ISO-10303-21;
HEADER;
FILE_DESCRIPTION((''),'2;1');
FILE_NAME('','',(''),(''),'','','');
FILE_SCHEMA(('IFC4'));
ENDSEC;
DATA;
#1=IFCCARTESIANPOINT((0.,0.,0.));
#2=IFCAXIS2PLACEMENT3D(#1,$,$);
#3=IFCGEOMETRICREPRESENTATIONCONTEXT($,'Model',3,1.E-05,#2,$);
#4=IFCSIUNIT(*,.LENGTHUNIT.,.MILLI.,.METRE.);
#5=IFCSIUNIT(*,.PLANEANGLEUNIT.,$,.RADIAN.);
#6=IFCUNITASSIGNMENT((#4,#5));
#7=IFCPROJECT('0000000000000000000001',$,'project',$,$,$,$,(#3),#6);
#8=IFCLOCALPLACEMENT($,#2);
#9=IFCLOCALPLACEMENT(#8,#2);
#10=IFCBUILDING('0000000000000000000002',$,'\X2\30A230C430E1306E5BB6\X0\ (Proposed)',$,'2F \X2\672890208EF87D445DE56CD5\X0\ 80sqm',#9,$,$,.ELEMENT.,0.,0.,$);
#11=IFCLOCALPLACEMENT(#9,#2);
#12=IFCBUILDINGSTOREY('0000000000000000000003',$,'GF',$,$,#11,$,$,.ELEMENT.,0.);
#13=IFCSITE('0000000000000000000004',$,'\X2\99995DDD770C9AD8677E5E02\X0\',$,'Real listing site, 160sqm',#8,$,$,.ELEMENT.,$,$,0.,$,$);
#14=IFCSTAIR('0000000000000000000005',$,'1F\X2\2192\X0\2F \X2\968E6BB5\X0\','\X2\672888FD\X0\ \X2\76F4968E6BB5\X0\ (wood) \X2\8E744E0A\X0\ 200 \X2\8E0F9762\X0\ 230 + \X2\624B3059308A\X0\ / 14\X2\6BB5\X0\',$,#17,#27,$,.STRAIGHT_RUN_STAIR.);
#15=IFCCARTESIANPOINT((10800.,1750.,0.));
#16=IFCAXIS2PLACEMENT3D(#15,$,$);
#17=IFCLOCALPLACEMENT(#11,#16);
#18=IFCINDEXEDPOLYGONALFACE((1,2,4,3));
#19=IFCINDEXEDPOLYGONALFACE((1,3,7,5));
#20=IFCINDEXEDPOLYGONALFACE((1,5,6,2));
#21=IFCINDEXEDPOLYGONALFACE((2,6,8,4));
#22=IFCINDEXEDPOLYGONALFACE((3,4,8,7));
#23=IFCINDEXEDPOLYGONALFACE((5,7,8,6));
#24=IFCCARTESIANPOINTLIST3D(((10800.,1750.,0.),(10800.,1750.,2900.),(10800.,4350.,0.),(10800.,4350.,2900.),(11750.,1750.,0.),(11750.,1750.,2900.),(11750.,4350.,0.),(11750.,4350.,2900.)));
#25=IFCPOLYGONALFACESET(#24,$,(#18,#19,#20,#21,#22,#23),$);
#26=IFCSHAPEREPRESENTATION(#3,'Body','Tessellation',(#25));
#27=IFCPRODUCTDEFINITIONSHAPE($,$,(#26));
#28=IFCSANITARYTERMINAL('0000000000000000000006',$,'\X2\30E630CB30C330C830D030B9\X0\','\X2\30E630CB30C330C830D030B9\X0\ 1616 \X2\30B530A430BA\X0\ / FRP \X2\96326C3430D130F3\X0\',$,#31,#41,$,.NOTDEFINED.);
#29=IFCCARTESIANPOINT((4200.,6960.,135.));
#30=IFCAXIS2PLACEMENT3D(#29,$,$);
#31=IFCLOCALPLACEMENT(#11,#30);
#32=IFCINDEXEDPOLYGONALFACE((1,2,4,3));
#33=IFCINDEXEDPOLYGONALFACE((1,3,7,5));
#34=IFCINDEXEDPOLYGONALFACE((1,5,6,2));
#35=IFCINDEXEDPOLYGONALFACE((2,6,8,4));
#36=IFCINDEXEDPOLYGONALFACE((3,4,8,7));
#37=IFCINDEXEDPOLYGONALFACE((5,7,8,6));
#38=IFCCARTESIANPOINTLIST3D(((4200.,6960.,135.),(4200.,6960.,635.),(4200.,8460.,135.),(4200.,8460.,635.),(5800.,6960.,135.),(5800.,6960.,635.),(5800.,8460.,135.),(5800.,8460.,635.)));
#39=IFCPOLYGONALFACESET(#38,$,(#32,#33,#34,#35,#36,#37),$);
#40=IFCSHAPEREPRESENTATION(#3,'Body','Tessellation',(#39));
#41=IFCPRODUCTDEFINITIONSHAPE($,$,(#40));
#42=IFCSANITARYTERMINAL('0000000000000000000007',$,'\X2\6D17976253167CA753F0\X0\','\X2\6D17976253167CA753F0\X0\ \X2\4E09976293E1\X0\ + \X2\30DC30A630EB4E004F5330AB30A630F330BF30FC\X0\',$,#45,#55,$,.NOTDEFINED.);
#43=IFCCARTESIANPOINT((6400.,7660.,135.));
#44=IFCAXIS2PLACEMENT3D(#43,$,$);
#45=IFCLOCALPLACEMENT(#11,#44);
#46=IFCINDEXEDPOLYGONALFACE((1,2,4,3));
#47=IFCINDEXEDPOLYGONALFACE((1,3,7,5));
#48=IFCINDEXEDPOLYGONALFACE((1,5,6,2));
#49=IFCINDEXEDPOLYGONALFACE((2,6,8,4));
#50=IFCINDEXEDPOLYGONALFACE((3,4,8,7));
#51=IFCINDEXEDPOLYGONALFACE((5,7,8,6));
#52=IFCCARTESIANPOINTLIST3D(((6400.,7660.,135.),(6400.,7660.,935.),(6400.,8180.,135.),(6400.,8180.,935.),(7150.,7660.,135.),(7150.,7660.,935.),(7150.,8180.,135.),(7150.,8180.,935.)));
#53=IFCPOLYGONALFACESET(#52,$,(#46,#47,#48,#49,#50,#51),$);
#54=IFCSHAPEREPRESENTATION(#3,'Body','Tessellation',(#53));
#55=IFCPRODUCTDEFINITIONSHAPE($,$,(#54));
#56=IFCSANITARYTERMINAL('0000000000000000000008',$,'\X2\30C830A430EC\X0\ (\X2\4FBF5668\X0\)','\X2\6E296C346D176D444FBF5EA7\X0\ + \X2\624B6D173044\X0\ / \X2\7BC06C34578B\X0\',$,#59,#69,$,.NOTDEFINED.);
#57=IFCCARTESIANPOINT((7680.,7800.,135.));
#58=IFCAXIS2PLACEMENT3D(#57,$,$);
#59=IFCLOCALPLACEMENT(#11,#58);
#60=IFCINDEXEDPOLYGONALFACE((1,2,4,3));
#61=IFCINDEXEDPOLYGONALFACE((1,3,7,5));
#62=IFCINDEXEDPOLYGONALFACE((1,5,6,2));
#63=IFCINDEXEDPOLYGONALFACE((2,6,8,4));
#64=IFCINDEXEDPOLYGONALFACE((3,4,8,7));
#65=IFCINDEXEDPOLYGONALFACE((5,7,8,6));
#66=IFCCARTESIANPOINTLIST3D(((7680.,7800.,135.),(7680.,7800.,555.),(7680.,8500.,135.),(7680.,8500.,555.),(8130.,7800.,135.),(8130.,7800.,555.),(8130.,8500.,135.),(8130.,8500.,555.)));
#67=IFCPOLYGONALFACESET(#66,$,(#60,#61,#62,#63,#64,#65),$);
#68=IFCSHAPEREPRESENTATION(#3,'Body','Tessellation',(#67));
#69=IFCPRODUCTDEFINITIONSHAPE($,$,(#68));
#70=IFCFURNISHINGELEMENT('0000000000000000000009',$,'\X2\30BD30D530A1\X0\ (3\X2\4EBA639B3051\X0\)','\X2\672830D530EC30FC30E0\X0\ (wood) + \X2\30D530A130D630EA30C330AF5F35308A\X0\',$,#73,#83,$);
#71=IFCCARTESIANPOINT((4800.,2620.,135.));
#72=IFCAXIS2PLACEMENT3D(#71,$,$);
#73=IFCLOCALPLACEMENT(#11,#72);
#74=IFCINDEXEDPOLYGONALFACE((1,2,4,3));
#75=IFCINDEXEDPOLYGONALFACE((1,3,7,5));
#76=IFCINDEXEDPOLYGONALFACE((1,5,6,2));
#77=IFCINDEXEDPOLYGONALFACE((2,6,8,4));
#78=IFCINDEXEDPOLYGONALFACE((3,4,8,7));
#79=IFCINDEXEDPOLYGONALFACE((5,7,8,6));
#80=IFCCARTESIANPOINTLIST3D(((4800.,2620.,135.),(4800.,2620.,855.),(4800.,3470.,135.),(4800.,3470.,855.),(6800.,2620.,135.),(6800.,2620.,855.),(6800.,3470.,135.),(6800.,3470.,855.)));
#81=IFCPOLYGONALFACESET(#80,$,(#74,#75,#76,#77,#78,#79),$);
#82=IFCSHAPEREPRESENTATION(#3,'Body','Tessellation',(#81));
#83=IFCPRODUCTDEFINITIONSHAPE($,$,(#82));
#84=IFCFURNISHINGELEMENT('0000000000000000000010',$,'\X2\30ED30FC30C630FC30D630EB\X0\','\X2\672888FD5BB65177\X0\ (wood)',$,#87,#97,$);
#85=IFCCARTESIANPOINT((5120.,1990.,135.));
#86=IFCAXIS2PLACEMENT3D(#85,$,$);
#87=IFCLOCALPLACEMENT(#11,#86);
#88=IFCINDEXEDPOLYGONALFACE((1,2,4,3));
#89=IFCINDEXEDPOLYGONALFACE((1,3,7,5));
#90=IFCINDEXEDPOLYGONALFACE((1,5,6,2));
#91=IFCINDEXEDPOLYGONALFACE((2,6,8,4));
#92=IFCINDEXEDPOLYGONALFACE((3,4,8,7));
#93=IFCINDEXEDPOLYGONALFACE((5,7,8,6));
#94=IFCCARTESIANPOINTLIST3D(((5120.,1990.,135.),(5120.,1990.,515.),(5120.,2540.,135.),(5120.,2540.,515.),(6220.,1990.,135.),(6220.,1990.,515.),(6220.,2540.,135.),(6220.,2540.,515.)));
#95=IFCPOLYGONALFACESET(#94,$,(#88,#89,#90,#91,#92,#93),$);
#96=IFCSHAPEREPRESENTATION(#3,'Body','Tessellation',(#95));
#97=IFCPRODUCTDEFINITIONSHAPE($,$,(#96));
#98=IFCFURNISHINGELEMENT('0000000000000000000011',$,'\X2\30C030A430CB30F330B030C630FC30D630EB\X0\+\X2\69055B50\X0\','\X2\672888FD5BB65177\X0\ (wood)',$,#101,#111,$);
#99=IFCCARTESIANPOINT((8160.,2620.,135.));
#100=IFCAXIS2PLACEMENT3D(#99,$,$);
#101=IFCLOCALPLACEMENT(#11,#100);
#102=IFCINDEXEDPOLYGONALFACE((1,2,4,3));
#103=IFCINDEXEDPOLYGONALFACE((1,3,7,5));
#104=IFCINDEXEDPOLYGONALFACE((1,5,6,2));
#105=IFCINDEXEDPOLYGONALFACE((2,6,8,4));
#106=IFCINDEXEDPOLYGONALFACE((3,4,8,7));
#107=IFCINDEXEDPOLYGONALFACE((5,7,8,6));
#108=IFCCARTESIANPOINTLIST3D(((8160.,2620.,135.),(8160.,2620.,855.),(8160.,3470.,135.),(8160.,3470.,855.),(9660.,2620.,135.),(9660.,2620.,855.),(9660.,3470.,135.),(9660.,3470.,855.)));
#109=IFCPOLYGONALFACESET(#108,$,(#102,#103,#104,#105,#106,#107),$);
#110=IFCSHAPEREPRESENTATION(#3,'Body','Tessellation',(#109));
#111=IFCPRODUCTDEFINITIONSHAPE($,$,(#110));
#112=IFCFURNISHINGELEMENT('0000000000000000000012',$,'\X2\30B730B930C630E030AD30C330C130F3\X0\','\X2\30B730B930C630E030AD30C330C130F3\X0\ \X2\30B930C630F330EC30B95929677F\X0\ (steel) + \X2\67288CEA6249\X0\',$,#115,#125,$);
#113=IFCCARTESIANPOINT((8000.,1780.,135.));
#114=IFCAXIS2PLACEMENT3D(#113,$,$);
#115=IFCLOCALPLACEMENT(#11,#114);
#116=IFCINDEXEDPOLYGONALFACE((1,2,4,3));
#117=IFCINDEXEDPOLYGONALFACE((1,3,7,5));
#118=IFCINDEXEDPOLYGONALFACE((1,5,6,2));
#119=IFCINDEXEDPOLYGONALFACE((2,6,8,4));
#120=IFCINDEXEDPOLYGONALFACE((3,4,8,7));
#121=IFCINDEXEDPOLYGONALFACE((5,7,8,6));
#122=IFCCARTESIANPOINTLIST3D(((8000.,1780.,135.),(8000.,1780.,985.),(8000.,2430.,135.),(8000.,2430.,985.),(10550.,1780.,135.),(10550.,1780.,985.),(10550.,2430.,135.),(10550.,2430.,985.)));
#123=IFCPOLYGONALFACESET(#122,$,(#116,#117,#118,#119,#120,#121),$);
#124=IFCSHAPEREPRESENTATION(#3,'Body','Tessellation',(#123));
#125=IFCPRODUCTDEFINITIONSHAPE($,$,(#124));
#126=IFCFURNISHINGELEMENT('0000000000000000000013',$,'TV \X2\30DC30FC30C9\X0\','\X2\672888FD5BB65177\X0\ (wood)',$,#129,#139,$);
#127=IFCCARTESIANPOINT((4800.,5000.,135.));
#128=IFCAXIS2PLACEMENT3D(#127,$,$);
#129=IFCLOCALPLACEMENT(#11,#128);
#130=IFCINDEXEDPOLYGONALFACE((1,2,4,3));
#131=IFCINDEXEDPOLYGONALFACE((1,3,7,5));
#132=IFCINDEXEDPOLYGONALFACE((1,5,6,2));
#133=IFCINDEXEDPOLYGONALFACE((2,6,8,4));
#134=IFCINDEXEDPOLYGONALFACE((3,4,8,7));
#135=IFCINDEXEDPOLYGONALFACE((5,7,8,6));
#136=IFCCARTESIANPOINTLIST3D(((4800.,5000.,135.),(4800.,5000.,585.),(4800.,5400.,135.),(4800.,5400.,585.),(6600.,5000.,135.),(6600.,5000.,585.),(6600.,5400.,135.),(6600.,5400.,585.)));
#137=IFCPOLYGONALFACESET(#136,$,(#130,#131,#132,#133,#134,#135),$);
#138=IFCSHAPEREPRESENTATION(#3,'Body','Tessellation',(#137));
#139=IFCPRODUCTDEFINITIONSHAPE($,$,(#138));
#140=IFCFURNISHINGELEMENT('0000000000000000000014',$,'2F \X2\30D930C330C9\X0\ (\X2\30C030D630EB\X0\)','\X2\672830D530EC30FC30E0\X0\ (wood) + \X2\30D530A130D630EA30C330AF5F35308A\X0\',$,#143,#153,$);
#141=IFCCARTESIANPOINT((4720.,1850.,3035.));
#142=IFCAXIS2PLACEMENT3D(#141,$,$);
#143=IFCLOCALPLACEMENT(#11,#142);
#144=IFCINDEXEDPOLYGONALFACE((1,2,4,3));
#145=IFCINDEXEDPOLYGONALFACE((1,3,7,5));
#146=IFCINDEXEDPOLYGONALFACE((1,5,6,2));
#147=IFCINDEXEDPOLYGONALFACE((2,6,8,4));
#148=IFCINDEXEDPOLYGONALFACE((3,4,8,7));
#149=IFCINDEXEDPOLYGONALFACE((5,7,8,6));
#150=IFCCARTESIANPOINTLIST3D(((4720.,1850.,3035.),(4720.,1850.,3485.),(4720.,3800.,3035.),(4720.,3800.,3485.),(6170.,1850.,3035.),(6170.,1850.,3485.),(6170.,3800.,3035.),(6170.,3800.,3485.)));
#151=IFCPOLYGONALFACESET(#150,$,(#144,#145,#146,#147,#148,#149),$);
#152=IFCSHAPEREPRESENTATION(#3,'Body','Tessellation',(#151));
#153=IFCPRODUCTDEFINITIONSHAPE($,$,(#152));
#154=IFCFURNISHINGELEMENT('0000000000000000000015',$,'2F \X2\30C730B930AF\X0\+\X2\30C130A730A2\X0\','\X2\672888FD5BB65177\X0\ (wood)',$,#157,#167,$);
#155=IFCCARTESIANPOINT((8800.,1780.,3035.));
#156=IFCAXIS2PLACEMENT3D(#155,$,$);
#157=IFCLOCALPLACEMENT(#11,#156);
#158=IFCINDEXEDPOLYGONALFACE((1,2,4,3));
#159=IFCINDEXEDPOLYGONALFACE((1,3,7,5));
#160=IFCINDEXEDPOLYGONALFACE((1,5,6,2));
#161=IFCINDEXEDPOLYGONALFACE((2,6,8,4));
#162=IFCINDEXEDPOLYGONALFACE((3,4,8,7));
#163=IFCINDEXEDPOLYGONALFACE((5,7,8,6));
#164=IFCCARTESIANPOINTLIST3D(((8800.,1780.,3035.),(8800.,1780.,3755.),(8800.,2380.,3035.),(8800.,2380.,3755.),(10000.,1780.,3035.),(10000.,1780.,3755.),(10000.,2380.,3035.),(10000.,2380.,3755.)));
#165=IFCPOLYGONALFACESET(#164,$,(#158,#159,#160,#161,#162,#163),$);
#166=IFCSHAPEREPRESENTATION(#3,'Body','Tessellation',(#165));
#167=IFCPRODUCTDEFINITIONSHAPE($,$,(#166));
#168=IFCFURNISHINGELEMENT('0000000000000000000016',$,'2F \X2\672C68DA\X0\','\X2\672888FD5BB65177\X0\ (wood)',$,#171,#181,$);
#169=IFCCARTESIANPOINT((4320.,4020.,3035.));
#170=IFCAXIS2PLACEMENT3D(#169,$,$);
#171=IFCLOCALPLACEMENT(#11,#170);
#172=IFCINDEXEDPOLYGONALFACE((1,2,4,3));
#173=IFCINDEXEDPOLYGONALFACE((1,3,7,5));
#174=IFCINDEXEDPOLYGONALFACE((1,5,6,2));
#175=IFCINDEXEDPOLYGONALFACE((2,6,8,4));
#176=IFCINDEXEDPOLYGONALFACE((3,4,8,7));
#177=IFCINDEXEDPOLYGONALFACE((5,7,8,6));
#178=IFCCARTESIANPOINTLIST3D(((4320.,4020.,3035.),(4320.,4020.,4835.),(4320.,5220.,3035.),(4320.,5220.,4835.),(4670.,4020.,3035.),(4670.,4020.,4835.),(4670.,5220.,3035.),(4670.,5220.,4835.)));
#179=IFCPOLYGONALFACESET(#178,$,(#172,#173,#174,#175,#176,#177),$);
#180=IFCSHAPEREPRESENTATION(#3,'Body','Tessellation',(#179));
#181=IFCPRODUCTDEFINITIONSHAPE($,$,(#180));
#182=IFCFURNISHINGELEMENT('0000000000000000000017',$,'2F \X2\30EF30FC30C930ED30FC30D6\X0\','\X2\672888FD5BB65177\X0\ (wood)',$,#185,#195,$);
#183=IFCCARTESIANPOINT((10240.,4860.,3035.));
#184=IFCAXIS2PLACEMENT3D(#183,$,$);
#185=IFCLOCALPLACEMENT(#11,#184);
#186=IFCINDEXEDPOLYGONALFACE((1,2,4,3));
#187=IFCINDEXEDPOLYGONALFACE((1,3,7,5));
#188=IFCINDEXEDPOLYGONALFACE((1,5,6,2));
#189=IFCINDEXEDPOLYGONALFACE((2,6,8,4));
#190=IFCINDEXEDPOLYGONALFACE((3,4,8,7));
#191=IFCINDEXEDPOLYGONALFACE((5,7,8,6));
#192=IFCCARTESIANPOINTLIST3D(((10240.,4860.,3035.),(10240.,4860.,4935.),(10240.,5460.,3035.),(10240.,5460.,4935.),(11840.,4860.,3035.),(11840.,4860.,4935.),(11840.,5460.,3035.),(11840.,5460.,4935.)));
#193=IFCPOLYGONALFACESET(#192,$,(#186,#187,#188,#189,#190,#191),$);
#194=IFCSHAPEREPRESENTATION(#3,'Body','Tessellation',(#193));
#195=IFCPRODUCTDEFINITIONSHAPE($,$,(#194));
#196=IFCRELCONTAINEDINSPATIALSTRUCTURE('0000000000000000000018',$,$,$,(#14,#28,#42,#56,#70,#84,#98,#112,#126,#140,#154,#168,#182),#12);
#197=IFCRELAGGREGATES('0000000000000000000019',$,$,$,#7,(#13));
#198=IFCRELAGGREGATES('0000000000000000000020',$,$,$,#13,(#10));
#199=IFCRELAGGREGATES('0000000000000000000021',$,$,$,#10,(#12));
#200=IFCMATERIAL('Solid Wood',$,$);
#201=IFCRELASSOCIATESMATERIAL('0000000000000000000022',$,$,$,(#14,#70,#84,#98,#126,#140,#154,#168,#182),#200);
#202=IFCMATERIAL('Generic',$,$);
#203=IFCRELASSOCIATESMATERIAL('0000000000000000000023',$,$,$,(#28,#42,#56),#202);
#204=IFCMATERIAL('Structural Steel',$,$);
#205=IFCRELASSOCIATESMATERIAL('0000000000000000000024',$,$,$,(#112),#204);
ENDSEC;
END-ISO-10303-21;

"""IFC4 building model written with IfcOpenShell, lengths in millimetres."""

from ifc_helpers import new_model, si_unit, frame, frame_2d, origin, place, context, project, spatial, rectangle, extrude, material, element, save


model = new_model("IFC4")

# Units and contexts
model_context = context("Model", 3, precision=1e-05, world=origin())
ifc_project = project(units=[si_unit("LENGTHUNIT", "METRE", prefix="MILLI"), si_unit("PLANEANGLEUNIT", "RADIAN")], contexts=[model_context])

# Site, building, storey
site_placement = place(None, origin())
site = spatial("IfcSite", under=ifc_project, at=site_placement, Name="香川県高松市", ObjectType="Real listing site, 160sqm", CompositionType="ELEMENT", RefElevation=0.0)
building_placement = place(site_placement, origin())
building = spatial("IfcBuilding", under=site, at=building_placement, Name="アツメの家 (Proposed)", ObjectType="2F 木造軸組工法 80sqm", CompositionType="ELEMENT", ElevationOfRefHeight=0.0, ElevationOfTerrain=0.0)
storey_placement = place(building_placement, origin())
storey = spatial("IfcBuildingStorey", under=building, at=storey_placement, Name="GF", CompositionType="ELEMENT", Elevation=0.0)

# Shared definitions
ifc_material_1 = material(Name="Solid Wood")

# Stair
stair_placement = place(storey_placement, frame((10800.0, 1750.0, 0.0)))
element("IfcStair", 1, at=stair_placement, inside=storey, material=ifc_material_1, Name="1F→2F 階段", Description="木製 直階段 (wood) 蹴上 200 踏面 230 + 手すり / 14段", PredefinedType="STRAIGHT_RUN_STAIR", context=model_context, shape_type="SweptSolid", body=[
    extrude(rectangle(XDim=950.0, YDim=2600.0, at=frame_2d((475.0, 1300.0))), frame((10800.0, 1750.0, 0.0)), (0.0, 0.0, 1.0), 2900.0),
])

# Sanitary terminals
ifc_material_2 = material(Name="Generic")
sanitary_terminal_1_placement = place(storey_placement, frame((4200.0, 6960.0, 135.0)))
element("IfcSanitaryTerminal", 2, at=sanitary_terminal_1_placement, inside=storey, material=ifc_material_2, Name="ユニットバス", Description="ユニットバス 1616 サイズ / FRP 防水パン", PredefinedType="NOTDEFINED", context=model_context, shape_type="SweptSolid", body=[
    extrude(rectangle(XDim=1600.0, YDim=1500.0, at=frame_2d((800.0, 750.0))), frame((4200.0, 6960.0, 135.0)), (0.0, 0.0, 1.0), 500.0),
])
sanitary_terminal_2_placement = place(storey_placement, frame((6400.0, 7660.0, 135.0)))
element("IfcSanitaryTerminal", 3, at=sanitary_terminal_2_placement, inside=storey, material=ifc_material_2, Name="洗面化粧台", Description="洗面化粧台 三面鏡 + ボウル一体カウンター", PredefinedType="NOTDEFINED", context=model_context, shape_type="SweptSolid", body=[
    extrude(rectangle(XDim=750.0, YDim=520.0, at=frame_2d((375.0, 260.0))), frame((6400.0, 7660.0, 135.0)), (0.0, 0.0, 1.0), 800.0),
])
sanitary_terminal_3_placement = place(storey_placement, frame((7680.0, 7800.0, 135.0)))
element("IfcSanitaryTerminal", 4, at=sanitary_terminal_3_placement, inside=storey, material=ifc_material_2, Name="トイレ (便器)", Description="温水洗浄便座 + 手洗い / 節水型", PredefinedType="NOTDEFINED", context=model_context, shape_type="SweptSolid", body=[
    extrude(rectangle(XDim=450.0, YDim=700.0, at=frame_2d((225.0, 350.0))), frame((7680.0, 7800.0, 135.0)), (0.0, 0.0, 1.0), 420.0),
])

# Furnishing elements
furnishing_1_placement = place(storey_placement, frame((4800.0, 2620.0, 135.0)))
element("IfcFurnishingElement", 5, at=furnishing_1_placement, inside=storey, material=ifc_material_1, Name="ソファ (3人掛け)", Description="木フレーム (wood) + ファブリック張り", context=model_context, shape_type="SweptSolid", body=[
    extrude(rectangle(XDim=2000.0, YDim=850.0, at=frame_2d((1000.0, 425.0))), frame((4800.0, 2620.0, 135.0)), (0.0, 0.0, 1.0), 720.0),
])
furnishing_2_placement = place(storey_placement, frame((5120.0, 1990.0, 135.0)))
element("IfcFurnishingElement", 6, at=furnishing_2_placement, inside=storey, material=ifc_material_1, Name="ローテーブル", Description="木製家具 (wood)", context=model_context, shape_type="SweptSolid", body=[
    extrude(rectangle(XDim=1100.0, YDim=550.0, at=frame_2d((550.0, 275.0))), frame((5120.0, 1990.0, 135.0)), (0.0, 0.0, 1.0), 380.0),
])
furnishing_3_placement = place(storey_placement, frame((8160.0, 2620.0, 135.0)))
element("IfcFurnishingElement", 7, at=furnishing_3_placement, inside=storey, material=ifc_material_1, Name="ダイニングテーブル+椅子", Description="木製家具 (wood)", context=model_context, shape_type="SweptSolid", body=[
    extrude(rectangle(XDim=1500.0, YDim=850.0, at=frame_2d((750.0, 425.0))), frame((8160.0, 2620.0, 135.0)), (0.0, 0.0, 1.0), 720.0),
])
ifc_material_3 = material(Name="Structural Steel")
furnishing_4_placement = place(storey_placement, frame((8000.0, 1780.0, 135.0)))
element("IfcFurnishingElement", 8, at=furnishing_4_placement, inside=storey, material=ifc_material_3, Name="システムキッチン", Description="システムキッチン ステンレス天板 (steel) + 木質扉", context=model_context, shape_type="SweptSolid", body=[
    extrude(rectangle(XDim=2550.0, YDim=650.0, at=frame_2d((1275.0, 325.0))), frame((8000.0, 1780.0, 135.0)), (0.0, 0.0, 1.0), 850.0),
])
furnishing_5_placement = place(storey_placement, frame((4800.0, 5000.0, 135.0)))
element("IfcFurnishingElement", 9, at=furnishing_5_placement, inside=storey, material=ifc_material_1, Name="TV ボード", Description="木製家具 (wood)", context=model_context, shape_type="SweptSolid", body=[
    extrude(rectangle(XDim=1800.0, YDim=400.0, at=frame_2d((900.0, 200.0))), frame((4800.0, 5000.0, 135.0)), (0.0, 0.0, 1.0), 450.0),
])
furnishing_6_placement = place(storey_placement, frame((4720.0, 1850.0, 3035.0)))
element("IfcFurnishingElement", 10, at=furnishing_6_placement, inside=storey, material=ifc_material_1, Name="2F ベッド (ダブル)", Description="木フレーム (wood) + ファブリック張り", context=model_context, shape_type="SweptSolid", body=[
    extrude(rectangle(XDim=1450.0, YDim=1950.0, at=frame_2d((725.0, 975.0))), frame((4720.0, 1850.0, 3035.0)), (0.0, 0.0, 1.0), 450.0),
])
furnishing_7_placement = place(storey_placement, frame((8800.0, 1780.0, 3035.0)))
element("IfcFurnishingElement", 11, at=furnishing_7_placement, inside=storey, material=ifc_material_1, Name="2F デスク+チェア", Description="木製家具 (wood)", context=model_context, shape_type="SweptSolid", body=[
    extrude(rectangle(XDim=1200.0, YDim=600.0, at=frame_2d((600.0, 300.0))), frame((8800.0, 1780.0, 3035.0)), (0.0, 0.0, 1.0), 720.0),
])
furnishing_8_placement = place(storey_placement, frame((4320.0, 4020.0, 3035.0)))
element("IfcFurnishingElement", 12, at=furnishing_8_placement, inside=storey, material=ifc_material_1, Name="2F 本棚", Description="木製家具 (wood)", context=model_context, shape_type="SweptSolid", body=[
    extrude(rectangle(XDim=350.0, YDim=1200.0, at=frame_2d((175.0, 600.0))), frame((4320.0, 4020.0, 3035.0)), (0.0, 0.0, 1.0), 1800.0),
])
furnishing_9_placement = place(storey_placement, frame((10240.0, 4860.0, 3035.0)))
element("IfcFurnishingElement", 13, at=furnishing_9_placement, inside=storey, material=ifc_material_1, Name="2F ワードローブ", Description="木製家具 (wood)", context=model_context, shape_type="SweptSolid", body=[
    extrude(rectangle(XDim=1600.0, YDim=600.0, at=frame_2d((800.0, 300.0))), frame((10240.0, 4860.0, 3035.0)), (0.0, 0.0, 1.0), 1900.0),
])

save(model, "model.ifc")
